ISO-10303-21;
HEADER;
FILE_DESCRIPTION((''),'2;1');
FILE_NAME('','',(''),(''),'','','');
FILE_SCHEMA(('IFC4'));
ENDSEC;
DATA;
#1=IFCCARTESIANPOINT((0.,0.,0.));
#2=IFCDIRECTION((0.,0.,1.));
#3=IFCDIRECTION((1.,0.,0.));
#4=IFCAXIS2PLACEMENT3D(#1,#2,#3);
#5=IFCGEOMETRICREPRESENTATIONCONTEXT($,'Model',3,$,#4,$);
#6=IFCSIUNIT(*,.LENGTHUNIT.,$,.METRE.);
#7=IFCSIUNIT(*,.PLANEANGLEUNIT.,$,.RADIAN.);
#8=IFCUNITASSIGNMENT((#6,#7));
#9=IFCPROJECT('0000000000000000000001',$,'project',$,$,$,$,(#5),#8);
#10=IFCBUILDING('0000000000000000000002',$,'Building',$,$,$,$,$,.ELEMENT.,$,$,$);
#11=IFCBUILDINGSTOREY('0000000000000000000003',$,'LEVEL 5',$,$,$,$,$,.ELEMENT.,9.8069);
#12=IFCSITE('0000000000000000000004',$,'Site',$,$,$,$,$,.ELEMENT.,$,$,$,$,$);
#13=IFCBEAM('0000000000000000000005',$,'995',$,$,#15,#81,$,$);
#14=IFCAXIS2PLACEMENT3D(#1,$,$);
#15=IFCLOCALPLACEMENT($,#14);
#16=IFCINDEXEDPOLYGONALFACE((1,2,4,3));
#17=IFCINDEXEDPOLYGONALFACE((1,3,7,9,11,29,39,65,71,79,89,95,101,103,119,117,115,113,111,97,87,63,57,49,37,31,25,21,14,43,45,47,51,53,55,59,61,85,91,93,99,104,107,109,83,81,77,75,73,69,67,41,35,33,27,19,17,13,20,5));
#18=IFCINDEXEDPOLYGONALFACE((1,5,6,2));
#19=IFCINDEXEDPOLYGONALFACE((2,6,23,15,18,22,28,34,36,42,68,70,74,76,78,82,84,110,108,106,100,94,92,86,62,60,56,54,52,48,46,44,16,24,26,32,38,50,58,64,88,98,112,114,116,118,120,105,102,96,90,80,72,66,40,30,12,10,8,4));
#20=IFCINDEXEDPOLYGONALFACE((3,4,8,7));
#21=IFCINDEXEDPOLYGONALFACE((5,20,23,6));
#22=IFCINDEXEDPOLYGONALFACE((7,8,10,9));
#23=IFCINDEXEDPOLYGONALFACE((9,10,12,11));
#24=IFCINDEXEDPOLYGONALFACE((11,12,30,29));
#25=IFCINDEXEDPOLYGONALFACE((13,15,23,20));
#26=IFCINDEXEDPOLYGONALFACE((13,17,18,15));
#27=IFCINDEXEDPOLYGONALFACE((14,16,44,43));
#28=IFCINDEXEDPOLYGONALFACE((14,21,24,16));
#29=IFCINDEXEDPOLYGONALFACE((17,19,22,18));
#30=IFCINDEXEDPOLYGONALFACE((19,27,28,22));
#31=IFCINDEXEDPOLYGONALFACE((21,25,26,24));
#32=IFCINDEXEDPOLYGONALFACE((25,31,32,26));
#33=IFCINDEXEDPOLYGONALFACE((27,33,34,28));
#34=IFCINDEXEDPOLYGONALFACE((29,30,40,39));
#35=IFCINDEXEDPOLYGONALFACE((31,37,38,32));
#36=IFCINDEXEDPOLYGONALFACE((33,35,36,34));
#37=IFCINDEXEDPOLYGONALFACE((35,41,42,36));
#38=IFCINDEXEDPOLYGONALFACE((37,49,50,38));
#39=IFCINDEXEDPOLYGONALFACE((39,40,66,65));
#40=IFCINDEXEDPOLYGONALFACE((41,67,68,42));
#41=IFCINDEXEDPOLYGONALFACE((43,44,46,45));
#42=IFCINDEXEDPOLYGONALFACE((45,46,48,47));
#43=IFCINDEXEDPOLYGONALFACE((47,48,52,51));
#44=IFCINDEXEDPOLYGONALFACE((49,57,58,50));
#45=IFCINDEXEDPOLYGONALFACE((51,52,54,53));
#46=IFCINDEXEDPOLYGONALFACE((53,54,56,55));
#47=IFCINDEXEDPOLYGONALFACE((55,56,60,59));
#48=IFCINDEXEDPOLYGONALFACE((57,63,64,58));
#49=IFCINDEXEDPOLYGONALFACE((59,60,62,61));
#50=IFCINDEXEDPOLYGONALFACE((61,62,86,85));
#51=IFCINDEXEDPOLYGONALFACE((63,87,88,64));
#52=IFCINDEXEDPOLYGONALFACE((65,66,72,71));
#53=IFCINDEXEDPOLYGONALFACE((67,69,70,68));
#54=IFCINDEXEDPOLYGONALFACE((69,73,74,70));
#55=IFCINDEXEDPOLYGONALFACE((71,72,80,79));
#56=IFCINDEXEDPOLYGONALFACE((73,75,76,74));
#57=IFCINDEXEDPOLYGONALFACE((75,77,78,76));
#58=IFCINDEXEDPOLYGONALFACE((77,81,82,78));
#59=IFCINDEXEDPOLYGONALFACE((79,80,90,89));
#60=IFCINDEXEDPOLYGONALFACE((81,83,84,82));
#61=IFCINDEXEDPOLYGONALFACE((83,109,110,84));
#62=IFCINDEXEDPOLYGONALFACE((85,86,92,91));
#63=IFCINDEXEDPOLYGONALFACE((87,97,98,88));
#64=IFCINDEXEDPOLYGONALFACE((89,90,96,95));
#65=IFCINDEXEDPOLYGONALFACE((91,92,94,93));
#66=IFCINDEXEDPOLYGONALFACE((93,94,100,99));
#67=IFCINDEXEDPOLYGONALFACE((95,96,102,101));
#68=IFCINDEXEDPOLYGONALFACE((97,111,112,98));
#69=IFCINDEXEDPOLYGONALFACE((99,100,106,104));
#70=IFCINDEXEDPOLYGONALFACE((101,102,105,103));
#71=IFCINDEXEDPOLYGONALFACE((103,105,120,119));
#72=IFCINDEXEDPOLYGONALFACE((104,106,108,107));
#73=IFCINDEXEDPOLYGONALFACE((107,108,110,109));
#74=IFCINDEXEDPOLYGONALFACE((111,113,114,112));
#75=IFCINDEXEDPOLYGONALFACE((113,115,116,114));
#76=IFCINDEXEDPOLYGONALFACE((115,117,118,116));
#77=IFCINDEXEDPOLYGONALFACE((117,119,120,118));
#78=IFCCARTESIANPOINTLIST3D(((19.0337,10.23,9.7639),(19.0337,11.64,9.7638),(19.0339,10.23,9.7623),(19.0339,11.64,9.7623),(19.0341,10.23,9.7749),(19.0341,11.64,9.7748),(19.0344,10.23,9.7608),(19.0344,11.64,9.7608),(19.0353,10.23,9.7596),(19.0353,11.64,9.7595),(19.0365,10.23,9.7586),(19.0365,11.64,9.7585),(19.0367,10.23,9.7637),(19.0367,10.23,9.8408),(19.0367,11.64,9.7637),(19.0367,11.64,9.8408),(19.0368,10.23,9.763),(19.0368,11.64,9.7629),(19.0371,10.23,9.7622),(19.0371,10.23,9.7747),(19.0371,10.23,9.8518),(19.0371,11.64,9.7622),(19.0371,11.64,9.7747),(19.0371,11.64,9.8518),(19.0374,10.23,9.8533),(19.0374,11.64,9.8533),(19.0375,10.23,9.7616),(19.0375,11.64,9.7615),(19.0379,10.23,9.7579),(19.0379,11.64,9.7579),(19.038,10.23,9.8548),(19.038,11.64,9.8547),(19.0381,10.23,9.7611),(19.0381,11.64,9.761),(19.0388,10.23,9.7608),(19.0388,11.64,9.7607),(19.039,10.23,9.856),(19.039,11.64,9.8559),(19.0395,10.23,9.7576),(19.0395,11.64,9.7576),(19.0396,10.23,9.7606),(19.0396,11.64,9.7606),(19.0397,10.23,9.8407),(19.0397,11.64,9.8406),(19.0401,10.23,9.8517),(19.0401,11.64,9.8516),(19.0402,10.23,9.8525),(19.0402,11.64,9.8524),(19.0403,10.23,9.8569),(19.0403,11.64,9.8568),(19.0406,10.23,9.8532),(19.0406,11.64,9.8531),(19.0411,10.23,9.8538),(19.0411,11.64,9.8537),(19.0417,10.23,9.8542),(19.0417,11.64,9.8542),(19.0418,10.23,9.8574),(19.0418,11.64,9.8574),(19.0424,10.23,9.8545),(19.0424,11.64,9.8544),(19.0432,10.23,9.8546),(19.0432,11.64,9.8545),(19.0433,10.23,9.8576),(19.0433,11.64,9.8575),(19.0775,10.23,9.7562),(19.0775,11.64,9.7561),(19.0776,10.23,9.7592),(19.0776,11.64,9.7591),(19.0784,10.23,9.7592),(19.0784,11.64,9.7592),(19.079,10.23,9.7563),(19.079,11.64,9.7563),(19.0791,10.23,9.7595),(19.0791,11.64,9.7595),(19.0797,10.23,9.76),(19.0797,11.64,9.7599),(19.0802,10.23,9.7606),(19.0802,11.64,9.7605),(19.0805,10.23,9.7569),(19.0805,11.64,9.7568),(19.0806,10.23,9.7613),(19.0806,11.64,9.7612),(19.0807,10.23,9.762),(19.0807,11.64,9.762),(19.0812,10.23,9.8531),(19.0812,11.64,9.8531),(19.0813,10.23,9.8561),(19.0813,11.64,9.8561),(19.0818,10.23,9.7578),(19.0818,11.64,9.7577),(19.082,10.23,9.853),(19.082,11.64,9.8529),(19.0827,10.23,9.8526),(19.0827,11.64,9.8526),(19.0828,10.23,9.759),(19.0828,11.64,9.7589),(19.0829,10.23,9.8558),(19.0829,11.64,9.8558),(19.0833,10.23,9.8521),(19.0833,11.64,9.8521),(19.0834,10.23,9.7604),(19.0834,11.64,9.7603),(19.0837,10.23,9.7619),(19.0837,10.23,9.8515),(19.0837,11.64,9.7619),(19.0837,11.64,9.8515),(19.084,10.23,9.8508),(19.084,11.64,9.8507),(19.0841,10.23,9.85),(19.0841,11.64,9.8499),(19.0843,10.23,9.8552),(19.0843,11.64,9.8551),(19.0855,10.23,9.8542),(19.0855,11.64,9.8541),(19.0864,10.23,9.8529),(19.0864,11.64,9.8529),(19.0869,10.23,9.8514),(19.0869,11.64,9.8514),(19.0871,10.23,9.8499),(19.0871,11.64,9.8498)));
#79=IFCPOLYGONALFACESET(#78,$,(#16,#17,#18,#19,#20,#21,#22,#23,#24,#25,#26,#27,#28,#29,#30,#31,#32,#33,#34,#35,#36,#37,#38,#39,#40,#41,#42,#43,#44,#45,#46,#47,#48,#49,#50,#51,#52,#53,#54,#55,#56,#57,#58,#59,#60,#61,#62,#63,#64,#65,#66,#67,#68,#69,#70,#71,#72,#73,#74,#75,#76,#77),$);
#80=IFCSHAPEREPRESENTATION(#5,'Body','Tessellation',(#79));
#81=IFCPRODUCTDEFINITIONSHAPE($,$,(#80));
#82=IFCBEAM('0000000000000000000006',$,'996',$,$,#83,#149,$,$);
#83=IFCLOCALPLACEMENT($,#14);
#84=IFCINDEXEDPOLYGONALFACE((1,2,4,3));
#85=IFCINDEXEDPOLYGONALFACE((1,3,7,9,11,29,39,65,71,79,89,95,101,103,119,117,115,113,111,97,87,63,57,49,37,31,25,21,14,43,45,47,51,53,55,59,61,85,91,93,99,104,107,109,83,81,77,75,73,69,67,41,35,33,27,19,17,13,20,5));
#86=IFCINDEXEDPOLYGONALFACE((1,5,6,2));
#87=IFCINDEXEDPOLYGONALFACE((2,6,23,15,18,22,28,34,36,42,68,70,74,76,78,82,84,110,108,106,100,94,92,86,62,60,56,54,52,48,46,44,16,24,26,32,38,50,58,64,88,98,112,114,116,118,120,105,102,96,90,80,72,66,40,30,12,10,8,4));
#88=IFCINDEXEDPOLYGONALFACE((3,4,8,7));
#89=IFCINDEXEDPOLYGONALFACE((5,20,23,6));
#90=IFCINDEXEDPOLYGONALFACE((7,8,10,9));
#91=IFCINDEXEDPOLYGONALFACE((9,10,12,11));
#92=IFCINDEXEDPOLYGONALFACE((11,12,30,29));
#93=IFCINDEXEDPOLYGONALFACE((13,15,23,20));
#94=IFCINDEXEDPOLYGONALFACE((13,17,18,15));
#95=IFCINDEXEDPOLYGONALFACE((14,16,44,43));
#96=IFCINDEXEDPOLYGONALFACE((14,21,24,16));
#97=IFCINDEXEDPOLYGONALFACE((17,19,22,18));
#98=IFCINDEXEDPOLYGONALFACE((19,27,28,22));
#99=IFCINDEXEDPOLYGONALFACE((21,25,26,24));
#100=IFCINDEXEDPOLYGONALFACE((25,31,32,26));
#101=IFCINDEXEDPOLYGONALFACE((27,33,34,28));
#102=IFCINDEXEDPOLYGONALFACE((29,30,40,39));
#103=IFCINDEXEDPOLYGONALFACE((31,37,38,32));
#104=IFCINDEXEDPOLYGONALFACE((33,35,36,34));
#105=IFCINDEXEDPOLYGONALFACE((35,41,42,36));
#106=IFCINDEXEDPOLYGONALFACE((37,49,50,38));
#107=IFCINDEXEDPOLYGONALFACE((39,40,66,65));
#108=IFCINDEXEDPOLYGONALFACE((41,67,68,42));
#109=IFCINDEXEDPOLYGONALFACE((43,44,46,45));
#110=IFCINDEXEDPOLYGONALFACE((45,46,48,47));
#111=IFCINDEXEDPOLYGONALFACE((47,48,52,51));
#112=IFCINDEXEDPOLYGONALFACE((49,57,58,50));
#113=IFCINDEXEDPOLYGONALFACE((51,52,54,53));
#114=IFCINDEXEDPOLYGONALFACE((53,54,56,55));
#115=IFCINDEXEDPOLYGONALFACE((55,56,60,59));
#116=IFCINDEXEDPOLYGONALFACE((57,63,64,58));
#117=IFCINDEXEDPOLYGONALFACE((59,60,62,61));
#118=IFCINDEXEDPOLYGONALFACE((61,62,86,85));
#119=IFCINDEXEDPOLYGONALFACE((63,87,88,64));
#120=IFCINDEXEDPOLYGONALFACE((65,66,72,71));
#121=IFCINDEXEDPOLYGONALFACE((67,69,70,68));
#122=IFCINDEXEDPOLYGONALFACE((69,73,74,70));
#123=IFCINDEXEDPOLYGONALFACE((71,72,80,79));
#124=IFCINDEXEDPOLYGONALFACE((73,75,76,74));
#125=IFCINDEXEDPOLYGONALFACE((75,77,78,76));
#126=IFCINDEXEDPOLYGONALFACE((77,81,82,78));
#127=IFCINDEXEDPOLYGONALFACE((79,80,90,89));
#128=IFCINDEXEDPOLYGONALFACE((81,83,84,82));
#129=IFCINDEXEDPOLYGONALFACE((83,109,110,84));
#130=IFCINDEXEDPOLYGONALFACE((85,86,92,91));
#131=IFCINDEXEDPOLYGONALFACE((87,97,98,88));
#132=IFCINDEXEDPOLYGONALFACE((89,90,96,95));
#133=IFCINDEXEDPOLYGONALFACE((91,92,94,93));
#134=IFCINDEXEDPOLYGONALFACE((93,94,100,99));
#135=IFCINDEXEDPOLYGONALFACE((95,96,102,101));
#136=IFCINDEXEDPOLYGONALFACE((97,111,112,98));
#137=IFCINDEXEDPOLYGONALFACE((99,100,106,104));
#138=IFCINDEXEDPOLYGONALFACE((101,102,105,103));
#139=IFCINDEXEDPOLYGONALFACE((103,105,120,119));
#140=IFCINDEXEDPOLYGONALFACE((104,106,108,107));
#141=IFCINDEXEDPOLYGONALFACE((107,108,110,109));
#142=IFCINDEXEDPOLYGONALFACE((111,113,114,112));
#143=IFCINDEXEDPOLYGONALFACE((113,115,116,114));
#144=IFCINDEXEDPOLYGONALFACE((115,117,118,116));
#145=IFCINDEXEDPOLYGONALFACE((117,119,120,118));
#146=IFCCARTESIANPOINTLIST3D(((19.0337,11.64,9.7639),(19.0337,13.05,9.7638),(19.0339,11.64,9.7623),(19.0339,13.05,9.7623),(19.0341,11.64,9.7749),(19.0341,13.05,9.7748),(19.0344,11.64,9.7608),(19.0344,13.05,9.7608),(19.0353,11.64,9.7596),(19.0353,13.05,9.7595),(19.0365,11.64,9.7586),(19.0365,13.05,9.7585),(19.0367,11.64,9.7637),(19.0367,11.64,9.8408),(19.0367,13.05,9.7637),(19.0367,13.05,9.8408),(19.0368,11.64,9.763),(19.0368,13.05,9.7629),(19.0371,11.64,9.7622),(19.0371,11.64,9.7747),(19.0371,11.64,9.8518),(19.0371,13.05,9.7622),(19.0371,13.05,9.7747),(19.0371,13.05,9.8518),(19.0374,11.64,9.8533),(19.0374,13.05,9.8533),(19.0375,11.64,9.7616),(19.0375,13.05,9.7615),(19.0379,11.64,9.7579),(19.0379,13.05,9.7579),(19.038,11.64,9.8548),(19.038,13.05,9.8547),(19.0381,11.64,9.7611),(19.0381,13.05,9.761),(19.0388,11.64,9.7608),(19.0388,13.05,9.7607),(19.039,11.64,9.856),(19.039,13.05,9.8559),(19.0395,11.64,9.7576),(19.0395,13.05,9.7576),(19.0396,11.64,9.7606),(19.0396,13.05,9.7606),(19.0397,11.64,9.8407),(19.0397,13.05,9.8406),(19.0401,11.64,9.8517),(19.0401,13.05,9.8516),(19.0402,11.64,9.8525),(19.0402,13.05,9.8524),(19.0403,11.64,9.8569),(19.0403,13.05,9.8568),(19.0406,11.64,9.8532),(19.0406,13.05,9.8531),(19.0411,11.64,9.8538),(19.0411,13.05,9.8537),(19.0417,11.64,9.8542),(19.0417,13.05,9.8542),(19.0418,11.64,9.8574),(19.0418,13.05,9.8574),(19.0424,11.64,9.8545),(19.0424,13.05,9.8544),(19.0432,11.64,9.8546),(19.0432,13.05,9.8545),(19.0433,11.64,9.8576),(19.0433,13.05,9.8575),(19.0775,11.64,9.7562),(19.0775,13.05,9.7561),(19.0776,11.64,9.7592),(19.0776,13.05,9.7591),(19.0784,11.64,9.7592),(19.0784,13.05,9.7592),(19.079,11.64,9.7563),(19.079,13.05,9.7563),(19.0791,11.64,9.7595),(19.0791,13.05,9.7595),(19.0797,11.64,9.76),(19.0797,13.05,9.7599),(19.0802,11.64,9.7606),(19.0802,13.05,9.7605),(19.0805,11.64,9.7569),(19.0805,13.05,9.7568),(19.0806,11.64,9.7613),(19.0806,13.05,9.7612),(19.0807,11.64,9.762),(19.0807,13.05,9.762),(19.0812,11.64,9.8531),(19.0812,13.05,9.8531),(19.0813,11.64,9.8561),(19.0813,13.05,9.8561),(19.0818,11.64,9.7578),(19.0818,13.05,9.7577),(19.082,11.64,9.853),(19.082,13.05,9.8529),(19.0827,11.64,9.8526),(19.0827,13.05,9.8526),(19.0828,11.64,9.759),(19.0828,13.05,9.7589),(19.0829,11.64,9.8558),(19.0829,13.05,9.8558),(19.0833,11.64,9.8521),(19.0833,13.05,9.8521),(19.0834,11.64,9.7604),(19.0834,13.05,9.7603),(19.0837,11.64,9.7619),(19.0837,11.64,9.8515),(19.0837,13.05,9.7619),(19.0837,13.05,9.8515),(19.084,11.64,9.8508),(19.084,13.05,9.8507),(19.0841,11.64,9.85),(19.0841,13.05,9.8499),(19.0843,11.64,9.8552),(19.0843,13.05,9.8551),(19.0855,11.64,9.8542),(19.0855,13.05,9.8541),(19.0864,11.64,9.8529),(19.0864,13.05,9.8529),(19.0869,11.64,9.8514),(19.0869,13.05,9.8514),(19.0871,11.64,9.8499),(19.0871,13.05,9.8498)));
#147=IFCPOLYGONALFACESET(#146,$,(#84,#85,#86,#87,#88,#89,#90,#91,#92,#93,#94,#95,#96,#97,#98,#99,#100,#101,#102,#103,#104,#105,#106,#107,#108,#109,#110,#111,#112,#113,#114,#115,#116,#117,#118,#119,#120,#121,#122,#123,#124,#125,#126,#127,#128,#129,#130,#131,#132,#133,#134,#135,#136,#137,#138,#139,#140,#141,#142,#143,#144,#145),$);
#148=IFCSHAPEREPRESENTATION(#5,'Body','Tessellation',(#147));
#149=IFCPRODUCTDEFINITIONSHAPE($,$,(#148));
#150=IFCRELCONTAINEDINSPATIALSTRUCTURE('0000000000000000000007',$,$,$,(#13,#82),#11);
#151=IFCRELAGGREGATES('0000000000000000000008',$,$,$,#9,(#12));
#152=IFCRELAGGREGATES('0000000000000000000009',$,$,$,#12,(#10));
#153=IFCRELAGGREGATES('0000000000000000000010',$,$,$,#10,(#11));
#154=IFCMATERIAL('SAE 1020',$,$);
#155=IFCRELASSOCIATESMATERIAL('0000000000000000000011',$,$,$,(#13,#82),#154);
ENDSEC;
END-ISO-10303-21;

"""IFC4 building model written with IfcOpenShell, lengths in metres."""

from ifc_helpers import new_model, si_unit, frame, origin_with_axes, origin_2d_with_axis, place, context, project, spatial, c_section, extrude, material, material_profile, profile_set, profile_usage, element, save


model = new_model("IFC4")

# Units and contexts
model_context = context("Model", 3, world=origin_with_axes())
ifc_project = project(units=[si_unit("LENGTHUNIT", "METRE"), si_unit("PLANEANGLEUNIT", "RADIAN")], contexts=[model_context])

# Site, building, storey
site = spatial("IfcSite", under=ifc_project, Name="Site", CompositionType="ELEMENT")
building = spatial("IfcBuilding", under=site, Name="Building", CompositionType="ELEMENT")
storey = spatial("IfcBuildingStorey", under=building, Name="LEVEL 5", CompositionType="ELEMENT", Elevation=9.8069)

# Beams
ifc_material = material(Name="SAE 1020")
ifc_material_profile_1 = material_profile(ifc_material, c_section(Depth=0.1, Width=0.05, WallThickness=0.003, Girth=0.017, InternalFilletRadius=0.003, at=origin_2d_with_axis()))
ifc_profile_set_1 = profile_set([ifc_material_profile_1])
ifc_profile_usage_1 = profile_usage(ifc_profile_set_1, cardinal=10)
beam_1_placement = place(None, frame((19.0604, 10.23, 9.8069), z_axis=(0.0, 1.0, -0.00003), x_axis=(-0.999256, 0.000001, 0.038562)))
element("IfcBeam", 1, at=beam_1_placement, inside=storey, material=ifc_profile_usage_1, Name="995", context=model_context, shape_type="SweptSolid", body=[
    extrude(c_section(Depth=0.1, Width=0.05, WallThickness=0.003, Girth=0.017, InternalFilletRadius=0.003, at=origin_2d_with_axis()), origin_with_axes(), (0.0, 0.0, 1.0), 1.41),
])
ifc_material_profile_2 = material_profile(ifc_material, c_section(Depth=0.1, Width=0.05, WallThickness=0.003, Girth=0.017, InternalFilletRadius=0.003, at=origin_2d_with_axis()))
ifc_profile_set_2 = profile_set([ifc_material_profile_2])
ifc_profile_usage_2 = profile_usage(ifc_profile_set_2, cardinal=10)
beam_2_placement = place(None, frame((19.0604, 11.64, 9.8069), z_axis=(0.0, 1.0, -0.00003), x_axis=(-0.999256, 0.000001, 0.038562)))
element("IfcBeam", 2, at=beam_2_placement, inside=storey, material=ifc_profile_usage_2, Name="996", context=model_context, shape_type="SweptSolid", body=[
    extrude(c_section(Depth=0.1, Width=0.05, WallThickness=0.003, Girth=0.017, InternalFilletRadius=0.003, at=origin_2d_with_axis()), origin_with_axes(), (0.0, 0.0, 1.0), 1.41),
])

save(model, "model.ifc")
